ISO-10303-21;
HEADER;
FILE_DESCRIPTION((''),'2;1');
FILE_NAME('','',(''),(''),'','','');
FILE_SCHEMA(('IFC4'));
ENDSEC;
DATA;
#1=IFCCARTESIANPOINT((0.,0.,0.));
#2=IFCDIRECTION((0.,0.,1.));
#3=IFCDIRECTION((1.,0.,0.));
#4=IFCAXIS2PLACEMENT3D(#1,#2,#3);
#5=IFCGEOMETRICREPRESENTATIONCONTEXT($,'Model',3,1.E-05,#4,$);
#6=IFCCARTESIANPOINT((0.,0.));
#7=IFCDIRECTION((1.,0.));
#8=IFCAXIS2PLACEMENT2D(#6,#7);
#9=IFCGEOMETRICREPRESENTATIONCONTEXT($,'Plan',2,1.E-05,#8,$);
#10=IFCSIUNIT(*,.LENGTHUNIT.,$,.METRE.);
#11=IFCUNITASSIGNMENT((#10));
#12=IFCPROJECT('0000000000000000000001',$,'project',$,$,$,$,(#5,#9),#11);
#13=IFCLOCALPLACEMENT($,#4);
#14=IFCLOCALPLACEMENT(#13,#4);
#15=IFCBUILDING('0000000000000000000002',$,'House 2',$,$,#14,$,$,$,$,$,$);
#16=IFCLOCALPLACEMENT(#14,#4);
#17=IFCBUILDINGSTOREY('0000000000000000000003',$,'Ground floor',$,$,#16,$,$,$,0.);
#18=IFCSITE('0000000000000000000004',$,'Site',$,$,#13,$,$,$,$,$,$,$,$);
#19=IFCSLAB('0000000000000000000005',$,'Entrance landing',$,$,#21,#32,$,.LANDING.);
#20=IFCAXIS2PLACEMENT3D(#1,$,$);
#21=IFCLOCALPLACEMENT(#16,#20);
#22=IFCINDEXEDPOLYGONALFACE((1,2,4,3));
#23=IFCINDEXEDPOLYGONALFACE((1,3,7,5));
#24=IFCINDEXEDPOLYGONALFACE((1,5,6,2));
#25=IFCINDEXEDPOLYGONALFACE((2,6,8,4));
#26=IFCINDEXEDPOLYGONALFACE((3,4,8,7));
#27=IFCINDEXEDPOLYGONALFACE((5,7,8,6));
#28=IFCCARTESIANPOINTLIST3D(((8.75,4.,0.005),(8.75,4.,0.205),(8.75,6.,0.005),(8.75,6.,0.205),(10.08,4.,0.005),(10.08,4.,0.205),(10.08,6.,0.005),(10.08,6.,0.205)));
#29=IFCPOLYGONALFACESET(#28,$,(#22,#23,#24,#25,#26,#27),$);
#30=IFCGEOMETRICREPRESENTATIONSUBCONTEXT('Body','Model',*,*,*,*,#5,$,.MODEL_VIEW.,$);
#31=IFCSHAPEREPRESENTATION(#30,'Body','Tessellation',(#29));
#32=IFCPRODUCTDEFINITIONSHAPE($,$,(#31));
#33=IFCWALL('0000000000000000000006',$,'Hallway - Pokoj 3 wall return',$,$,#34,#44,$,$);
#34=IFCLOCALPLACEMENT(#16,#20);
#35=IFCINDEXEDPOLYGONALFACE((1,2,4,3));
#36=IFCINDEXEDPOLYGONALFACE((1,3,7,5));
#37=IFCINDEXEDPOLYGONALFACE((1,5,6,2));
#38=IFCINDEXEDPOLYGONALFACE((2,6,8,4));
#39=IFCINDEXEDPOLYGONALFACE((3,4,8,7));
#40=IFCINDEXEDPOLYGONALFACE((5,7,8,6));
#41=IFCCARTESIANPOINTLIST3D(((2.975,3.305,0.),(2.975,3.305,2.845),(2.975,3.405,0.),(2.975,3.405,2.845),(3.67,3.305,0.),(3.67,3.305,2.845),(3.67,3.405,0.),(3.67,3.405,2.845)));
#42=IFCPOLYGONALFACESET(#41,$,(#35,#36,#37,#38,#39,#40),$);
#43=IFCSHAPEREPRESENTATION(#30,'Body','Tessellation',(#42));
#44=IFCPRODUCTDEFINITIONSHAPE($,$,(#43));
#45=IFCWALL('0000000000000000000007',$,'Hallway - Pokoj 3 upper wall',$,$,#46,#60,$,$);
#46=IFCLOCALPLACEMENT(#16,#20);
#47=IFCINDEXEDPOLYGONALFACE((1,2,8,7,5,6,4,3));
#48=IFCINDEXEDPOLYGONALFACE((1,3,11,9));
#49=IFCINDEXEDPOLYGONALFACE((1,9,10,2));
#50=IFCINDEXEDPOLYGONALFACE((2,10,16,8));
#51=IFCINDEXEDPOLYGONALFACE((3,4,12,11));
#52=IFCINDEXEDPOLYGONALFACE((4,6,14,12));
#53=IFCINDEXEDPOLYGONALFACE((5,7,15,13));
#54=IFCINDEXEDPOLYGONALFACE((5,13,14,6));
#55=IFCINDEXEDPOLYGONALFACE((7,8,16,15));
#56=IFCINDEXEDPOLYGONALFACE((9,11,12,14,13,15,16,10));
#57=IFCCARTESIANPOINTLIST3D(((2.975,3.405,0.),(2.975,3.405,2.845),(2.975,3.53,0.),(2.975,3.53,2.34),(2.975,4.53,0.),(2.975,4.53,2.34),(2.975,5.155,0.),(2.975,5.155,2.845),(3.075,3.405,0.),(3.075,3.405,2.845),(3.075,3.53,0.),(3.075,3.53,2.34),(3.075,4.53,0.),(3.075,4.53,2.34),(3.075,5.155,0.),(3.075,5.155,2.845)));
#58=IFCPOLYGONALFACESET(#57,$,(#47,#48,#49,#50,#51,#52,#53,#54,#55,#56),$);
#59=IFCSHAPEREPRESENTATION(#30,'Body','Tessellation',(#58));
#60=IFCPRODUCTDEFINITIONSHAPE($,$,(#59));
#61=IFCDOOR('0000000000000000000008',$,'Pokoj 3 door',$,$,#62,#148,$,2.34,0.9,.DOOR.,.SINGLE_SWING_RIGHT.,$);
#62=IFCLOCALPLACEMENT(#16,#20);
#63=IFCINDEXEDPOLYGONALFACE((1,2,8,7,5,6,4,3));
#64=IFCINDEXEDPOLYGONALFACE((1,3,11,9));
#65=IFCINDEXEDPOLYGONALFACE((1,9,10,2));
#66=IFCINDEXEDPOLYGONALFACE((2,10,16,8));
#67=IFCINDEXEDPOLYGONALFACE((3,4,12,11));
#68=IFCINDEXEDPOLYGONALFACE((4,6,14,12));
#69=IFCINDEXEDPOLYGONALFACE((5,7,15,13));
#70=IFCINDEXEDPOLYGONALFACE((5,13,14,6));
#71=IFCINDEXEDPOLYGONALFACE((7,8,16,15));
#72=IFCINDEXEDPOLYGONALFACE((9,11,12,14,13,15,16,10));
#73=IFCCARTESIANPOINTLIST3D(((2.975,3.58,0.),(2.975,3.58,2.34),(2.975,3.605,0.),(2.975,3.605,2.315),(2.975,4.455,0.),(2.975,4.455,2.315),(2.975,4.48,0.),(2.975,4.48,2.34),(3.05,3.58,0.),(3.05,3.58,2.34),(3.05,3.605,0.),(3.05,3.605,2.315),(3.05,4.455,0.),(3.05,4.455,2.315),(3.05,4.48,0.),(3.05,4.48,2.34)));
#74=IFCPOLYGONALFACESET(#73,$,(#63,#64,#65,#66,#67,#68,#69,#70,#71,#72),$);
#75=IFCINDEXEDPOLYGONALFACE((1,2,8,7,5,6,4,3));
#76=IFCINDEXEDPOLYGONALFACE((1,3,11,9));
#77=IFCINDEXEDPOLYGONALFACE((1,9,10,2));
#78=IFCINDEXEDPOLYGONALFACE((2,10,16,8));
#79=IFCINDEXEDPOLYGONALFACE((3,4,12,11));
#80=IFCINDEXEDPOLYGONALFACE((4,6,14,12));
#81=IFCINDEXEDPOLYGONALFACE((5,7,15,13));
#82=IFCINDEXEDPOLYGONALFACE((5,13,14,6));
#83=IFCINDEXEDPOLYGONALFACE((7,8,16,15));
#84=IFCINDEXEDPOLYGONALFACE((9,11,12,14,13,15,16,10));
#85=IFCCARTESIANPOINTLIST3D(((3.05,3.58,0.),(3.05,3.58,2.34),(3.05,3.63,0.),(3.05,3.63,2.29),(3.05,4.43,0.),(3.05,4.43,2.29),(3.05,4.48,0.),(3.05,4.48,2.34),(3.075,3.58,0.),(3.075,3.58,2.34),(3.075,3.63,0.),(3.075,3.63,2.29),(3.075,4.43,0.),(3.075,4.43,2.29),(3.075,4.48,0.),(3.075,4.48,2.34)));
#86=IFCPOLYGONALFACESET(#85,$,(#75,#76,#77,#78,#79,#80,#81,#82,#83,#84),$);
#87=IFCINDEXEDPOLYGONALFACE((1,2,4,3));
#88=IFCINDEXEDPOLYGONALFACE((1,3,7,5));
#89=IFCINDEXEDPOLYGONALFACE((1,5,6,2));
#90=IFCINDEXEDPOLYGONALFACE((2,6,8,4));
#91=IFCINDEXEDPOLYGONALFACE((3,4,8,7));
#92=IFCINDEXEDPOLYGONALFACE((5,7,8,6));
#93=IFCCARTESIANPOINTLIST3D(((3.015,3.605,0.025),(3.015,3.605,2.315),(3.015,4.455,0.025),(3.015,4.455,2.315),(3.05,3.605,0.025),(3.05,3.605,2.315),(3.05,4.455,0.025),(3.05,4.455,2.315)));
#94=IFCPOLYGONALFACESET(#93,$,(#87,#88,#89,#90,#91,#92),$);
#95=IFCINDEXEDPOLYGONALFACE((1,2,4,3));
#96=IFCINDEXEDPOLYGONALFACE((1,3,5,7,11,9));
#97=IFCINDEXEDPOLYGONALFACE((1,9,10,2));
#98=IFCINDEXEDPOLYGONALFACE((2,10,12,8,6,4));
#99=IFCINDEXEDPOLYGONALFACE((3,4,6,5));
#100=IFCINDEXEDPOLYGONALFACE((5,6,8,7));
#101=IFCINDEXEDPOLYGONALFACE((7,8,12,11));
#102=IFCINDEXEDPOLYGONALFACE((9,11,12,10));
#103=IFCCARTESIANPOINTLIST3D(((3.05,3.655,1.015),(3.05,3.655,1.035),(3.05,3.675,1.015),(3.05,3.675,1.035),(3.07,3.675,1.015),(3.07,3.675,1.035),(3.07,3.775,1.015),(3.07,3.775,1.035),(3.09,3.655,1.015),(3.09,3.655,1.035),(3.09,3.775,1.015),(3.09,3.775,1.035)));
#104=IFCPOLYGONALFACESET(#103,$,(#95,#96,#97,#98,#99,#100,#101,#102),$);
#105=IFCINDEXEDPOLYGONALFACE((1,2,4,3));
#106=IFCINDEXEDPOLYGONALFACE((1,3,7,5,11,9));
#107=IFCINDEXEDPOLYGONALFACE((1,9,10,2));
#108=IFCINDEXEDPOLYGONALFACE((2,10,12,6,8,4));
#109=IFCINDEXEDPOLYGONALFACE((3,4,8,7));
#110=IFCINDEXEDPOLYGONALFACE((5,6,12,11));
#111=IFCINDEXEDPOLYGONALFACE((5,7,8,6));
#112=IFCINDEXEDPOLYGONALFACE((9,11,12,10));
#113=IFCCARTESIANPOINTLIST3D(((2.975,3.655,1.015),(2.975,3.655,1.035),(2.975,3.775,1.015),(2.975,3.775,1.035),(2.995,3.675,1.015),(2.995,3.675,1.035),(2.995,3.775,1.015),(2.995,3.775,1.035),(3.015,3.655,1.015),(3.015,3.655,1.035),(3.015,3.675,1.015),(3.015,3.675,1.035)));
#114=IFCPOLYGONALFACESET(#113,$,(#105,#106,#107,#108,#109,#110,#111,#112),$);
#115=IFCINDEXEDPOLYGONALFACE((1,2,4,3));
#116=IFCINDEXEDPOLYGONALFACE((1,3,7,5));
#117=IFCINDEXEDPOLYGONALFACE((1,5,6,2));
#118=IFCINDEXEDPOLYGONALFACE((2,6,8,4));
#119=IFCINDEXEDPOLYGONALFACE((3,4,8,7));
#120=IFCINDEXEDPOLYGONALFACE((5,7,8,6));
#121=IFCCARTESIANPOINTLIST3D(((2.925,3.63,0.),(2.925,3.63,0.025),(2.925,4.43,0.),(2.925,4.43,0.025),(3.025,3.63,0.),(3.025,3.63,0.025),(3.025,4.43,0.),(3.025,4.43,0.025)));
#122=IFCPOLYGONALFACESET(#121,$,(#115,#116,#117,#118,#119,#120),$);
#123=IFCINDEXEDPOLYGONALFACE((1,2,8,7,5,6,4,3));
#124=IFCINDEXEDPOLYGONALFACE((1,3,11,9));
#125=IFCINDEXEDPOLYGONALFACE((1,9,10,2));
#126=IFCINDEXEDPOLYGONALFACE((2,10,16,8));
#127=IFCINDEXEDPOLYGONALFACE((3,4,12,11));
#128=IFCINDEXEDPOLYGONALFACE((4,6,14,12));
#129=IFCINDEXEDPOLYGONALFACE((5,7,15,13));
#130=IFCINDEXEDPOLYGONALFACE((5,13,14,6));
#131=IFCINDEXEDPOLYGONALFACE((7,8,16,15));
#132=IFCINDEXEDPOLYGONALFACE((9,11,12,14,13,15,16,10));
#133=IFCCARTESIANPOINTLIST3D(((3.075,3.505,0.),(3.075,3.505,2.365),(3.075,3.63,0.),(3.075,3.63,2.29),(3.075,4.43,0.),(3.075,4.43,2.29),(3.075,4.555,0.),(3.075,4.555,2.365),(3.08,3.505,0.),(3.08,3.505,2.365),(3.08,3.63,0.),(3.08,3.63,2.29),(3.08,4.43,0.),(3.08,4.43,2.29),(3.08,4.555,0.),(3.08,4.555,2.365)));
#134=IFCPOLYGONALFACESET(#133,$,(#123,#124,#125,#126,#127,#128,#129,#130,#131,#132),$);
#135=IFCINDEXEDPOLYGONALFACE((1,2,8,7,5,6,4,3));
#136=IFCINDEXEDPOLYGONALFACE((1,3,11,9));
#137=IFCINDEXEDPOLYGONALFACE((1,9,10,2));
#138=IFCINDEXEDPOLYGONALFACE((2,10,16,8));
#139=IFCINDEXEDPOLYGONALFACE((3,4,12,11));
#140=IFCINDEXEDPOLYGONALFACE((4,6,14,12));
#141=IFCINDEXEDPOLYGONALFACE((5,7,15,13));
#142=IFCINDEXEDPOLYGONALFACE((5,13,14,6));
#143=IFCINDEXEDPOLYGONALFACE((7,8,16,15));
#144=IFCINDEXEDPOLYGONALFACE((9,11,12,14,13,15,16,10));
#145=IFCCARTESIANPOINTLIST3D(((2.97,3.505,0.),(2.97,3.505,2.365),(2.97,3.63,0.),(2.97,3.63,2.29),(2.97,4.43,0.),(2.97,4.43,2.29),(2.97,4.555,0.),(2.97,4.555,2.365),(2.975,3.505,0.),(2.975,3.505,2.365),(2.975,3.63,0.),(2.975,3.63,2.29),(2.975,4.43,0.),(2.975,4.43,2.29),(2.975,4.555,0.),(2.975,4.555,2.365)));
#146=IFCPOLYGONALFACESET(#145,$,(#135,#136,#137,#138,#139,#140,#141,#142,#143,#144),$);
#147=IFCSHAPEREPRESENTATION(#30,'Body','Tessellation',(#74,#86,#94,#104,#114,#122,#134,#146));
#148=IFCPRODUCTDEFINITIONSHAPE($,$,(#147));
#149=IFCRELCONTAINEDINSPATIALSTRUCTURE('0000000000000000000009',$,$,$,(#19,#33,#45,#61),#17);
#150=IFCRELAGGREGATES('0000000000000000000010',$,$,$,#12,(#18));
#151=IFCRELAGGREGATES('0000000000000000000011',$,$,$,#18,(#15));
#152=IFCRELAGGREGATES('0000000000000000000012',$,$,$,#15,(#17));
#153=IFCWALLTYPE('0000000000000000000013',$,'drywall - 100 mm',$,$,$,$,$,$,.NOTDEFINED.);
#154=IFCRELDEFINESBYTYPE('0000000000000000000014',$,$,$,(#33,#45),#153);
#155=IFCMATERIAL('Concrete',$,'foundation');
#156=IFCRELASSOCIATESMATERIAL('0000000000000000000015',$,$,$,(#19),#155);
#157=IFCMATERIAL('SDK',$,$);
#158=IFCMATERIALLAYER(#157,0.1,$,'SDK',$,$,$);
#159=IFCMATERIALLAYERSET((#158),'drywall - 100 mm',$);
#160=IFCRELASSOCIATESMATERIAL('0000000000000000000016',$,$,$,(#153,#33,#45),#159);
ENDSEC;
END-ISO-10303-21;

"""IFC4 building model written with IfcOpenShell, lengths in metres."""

from ifc_helpers import new_model, entity, si_unit, frame, origin_with_axes, origin_2d_with_axis, place, context, subcontext, project, spatial, line, indexed_curve, outline, extrude, shape, source, transform, mapped, material, layer, layer_set, layer_usage, type_object, element, fill, save


model = new_model("IFC4")

# Units and contexts
model_context = context("Model", 3, precision=1e-05, world=origin_with_axes())
plan_context = context("Plan", 2, precision=1e-05, world=origin_2d_with_axis())
body_context_1 = subcontext(model_context, "Body", "Model", "MODEL_VIEW")
body_context_2 = subcontext(plan_context, "Body", "Plan", "PLAN_VIEW")
ifc_project = project(units=[si_unit("LENGTHUNIT", "METRE")], contexts=[model_context, plan_context])

# Site, building, storey
site_placement = place(None, origin_with_axes())
site = spatial("IfcSite", under=ifc_project, at=site_placement, Name="Site")
building_placement = place(site_placement, origin_with_axes())
building = spatial("IfcBuilding", under=site, at=building_placement, Name="House 2")
storey_placement = place(building_placement, origin_with_axes())
storey = spatial("IfcBuildingStorey", under=building, at=storey_placement, Name="Ground floor", Elevation=0.0)

# Slab
ifc_material_1 = material(Name="Concrete", Category="foundation")
slab_placement = place(storey_placement, frame((8.75, 4.0, 0.005), z_axis=(0.0, 0.0, 1.0), x_axis=(1.0, 0.0, 0.0)))
element("IfcSlab", 1, at=slab_placement, inside=storey, material=ifc_material_1, Name="Entrance landing", PredefinedType="LANDING", context=body_context_1, shape_type="SweptSolid", body=[
    extrude(outline(indexed_curve([(0.0, 0.0), (1.33, 0.0), (1.33, 2.0), (0.0, 2.0)])), None, (0.0, 0.0, 1.0), 0.2),
])

# Wall
ifc_material_2 = material(Name="SDK")
ifc_layer_1 = layer(ifc_material_2, 0.1, Name="SDK")
ifc_layer_set_1 = layer_set([ifc_layer_1], Name="drywall - 100 mm")
ifc_layer_usage_1 = layer_usage(ifc_layer_set_1, "AXIS2", "NEGATIVE", 0.05)
wall_type_1 = type_object("IfcWallType", Name="drywall - 100 mm", PredefinedType="NOTDEFINED", material=ifc_layer_set_1)
wall_1_placement = place(storey_placement, frame((2.975, 3.355, 0.0), z_axis=(0.0, 0.0, 1.0), x_axis=(1.0, 0.0, 0.0)))
element("IfcWall", 2, at=wall_1_placement, inside=storey, type_object=wall_type_1, material=ifc_layer_usage_1, Name="Hallway - Pokoj 3 wall return", context=body_context_1, shape_type="SweptSolid", body=[
    extrude(outline(indexed_curve([(0.0, 0.0), (0.0, 0.1), (0.695, 0.1), (0.695, 0.0), (0.0, 0.0)], self_intersect=False)), frame((0.0, -0.05, 0.0), z_axis=(0.0, 0.0, 1.0), x_axis=(1.0, 0.0, 0.0)), (0.0, 0.0, 1.0), 2.845),
])

# Wall, opening, door
ifc_layer_usage_2 = layer_usage(ifc_layer_set_1, "AXIS2", "NEGATIVE", 0.05)
wall_2_placement = place(storey_placement, frame((3.025, 3.405, 0.0), z_axis=(0.0, 0.0, 1.0), x_axis=(0.0, 1.0, 0.0)))
wall_2 = element("IfcWall", 3, at=wall_2_placement, inside=storey, type_object=wall_type_1, material=ifc_layer_usage_2, Name="Hallway - Pokoj 3 upper wall", context=body_context_1, shape_type="SweptSolid", body=[
    extrude(outline(indexed_curve([(0.0, 0.0), (0.0, 0.1), (1.75, 0.1), (1.75, 0.0), (0.0, 0.0)], self_intersect=False)), frame((0.0, -0.05, 0.0), z_axis=(0.0, 0.0, 1.0), x_axis=(1.0, 0.0, 0.0)), (0.0, 0.0, 1.0), 2.845),
])
opening_1_placement = place(wall_2_placement, frame((0.125, 0.0, 0.0), z_axis=(0.0, 0.0, 1.0), x_axis=(1.0, 0.0, 0.0)))
opening_1 = element("IfcOpeningElement", 4, at=opening_1_placement, cuts=wall_2, PredefinedType="OPENING", context=body_context_1, shape_type="SweptSolid", body=[
    extrude(outline(indexed_curve([(0.0, 0.0), (0.0, 0.2), (1.0, 0.2), (1.0, 0.0), (0.0, 0.0)], self_intersect=False)), frame((0.0, -0.1, 0.0), z_axis=(0.0, 0.0, 1.0), x_axis=(1.0, 0.0, 0.0)), (0.0, 0.0, 1.0), 2.34),
])
shared_indexed_poly_curve_1 = entity("IfcIndexedPolyCurve", entity("IfcCartesianPointList2D", [[-0.075, 0.0], [-0.075, 2.365], [0.975, 2.365], [0.975, 0.0], [0.85, 0.0], [0.85, 2.29], [0.05, 2.29], [0.05, 0.0]]), [entity("IfcLineIndex", [1, 2, 3, 4, 5, 6, 7, 8, 1])])
shared_shape_1 = source(origin_with_axes(), body_context_2, "Body", "Curve2D", [
    entity("IfcIndexedPolyCurve", entity("IfcCartesianPointList2D", [[0.0, -0.05], [0.0, 0.05], [0.025, 0.05], [0.025, -0.025], [0.05, -0.025], [0.05, -0.05]]), [entity("IfcLineIndex", [1, 2, 3, 4, 5, 6, 1])]),
    entity("IfcIndexedPolyCurve", entity("IfcCartesianPointList2D", [[0.9, -0.05], [0.9, 0.05], [0.875, 0.05], [0.875, -0.025], [0.85, -0.025], [0.85, -0.05]]), [entity("IfcLineIndex", [1, 2, 3, 4, 5, 6, 1])]),
    entity("IfcTrimmedCurve", entity("IfcEllipse", entity("IfcAxis2Placement2D", entity("IfcCartesianPoint", [0.84, 0.05]), entity("IfcDirection", [1.0, 0.0])), 0.815, 0.85), [entity("IfcCartesianPoint", [0.84, 0.9])], [entity("IfcCartesianPoint", [0.025, 0.05])], True, "CARTESIAN"),
    entity("IfcIndexedPolyCurve", entity("IfcCartesianPointList2D", [[0.875, 0.05], [0.84, 0.05], [0.84, 0.9], [0.875, 0.9]]), [entity("IfcLineIndex", [1, 2, 3, 4, 1])]),
])
door_1_placement = place(opening_1_placement, frame((0.05, 0.0, 0.0), z_axis=(0.0, 0.0, 1.0), x_axis=(1.0, 0.0, 0.0)))
door_1 = element("IfcDoor", 5, at=door_1_placement, inside=storey, Name="Pokoj 3 door", OperationType="SINGLE_SWING_RIGHT", OverallHeight=2.34, OverallWidth=0.9, PredefinedType="DOOR", shapes=[
    shape(body_context_1, "Body", "SweptSolid", [extrude(outline(indexed_curve([(0.0, 0.0), (0.0, 2.34), (0.9, 2.34), (0.9, 0.0), (0.875, 0.0), (0.875, 2.315), (0.025, 2.315), (0.025, 0.0)], segments=[line(1, 2, 3, 4, 5, 6, 7, 8, 1)])), frame((0.0, -0.025, 0.0), z_axis=(0.0, -1.0, 0.0), x_axis=(1.0, 0.0, 0.0)), (0.0, 0.0, -1.0), 0.075), extrude(outline(indexed_curve([(0.0, 0.0), (0.0, 2.34), (0.9, 2.34), (0.9, 0.0), (0.85, 0.0), (0.85, 2.29), (0.05, 2.29), (0.05, 0.0)], segments=[line(1, 2, 3, 4, 5, 6, 7, 8, 1)])), frame((0.0, -0.05, 0.0), z_axis=(0.0, -1.0, 0.0), x_axis=(1.0, 0.0, 0.0)), (0.0, 0.0, -1.0), 0.025), extrude(outline(indexed_curve([(0.0, 0.0), (0.85, 0.0), (0.85, 0.035), (0.0, 0.035)], segments=[line(1, 2, 3, 4, 1)])), frame((0.025, -0.025, 0.025), z_axis=(0.0, 0.0, 1.0), x_axis=(1.0, 0.0, 0.0)), (0.0, 0.0, 1.0), 2.29), extrude(outline(indexed_curve([(0.0, 0.0), (0.0, -0.04), (0.12, -0.04), (0.12, -0.02), (0.02, -0.02), (0.02, 0.0)], segments=[line(1, 2, 3, 4, 5, 6, 1)])), frame((0.075, -0.025, 1.015), z_axis=(0.0, 0.0, 1.0), x_axis=(1.0, 0.0, 0.0)), (0.0, 0.0, 1.0), 0.02), extrude(outline(indexed_curve([(0.0, 0.0), (0.0, 0.04), (0.12, 0.04), (0.12, 0.02), (0.02, 0.02), (0.02, 0.0)], segments=[line(1, 2, 3, 4, 5, 6, 1)])), frame((0.075, 0.01, 1.015), z_axis=(0.0, 0.0, 1.0), x_axis=(1.0, 0.0, 0.0)), (0.0, 0.0, 1.0), 0.02), extrude(outline(indexed_curve([(0.0, 0.0), (0.8, 0.0), (0.8, 0.1), (0.0, 0.1)], segments=[line(1, 2, 3, 4, 1)])), frame((0.05, 0.0, 0.0), z_axis=(0.0, 0.0, 1.0), x_axis=(1.0, 0.0, 0.0)), (0.0, 0.0, 1.0), 0.025), entity("IfcExtrudedAreaSolid", entity("IfcArbitraryClosedProfileDef", "AREA", None, shared_indexed_poly_curve_1), entity("IfcAxis2Placement3D", entity("IfcCartesianPoint", [0.0, -0.055, 0.0]), entity("IfcDirection", [0.0, -1.0, 0.0]), entity("IfcDirection", [1.0, 0.0, 0.0])), entity("IfcDirection", [0.0, 0.0, -1.0]), 0.005), entity("IfcExtrudedAreaSolid", entity("IfcArbitraryClosedProfileDef", "AREA", None, shared_indexed_poly_curve_1), entity("IfcAxis2Placement3D", entity("IfcCartesianPoint", [0.0, 0.05, 0.0]), entity("IfcDirection", [0.0, -1.0, 0.0]), entity("IfcDirection", [1.0, 0.0, 0.0])), entity("IfcDirection", [0.0, 0.0, -1.0]), 0.005)]),
    shape(body_context_2, "Body", "MappedRepresentation", [mapped(shared_shape_1, transform((0.0, 0.0, 1.17), x_axis=(1.0, 0.0, 0.0), y_axis=(0.0, 1.0, 0.0), z_axis=(0.0, 0.0, 1.0), scale=1.0))]),
])
fill(opening_1, door_1)

save(model, "model.ifc")
